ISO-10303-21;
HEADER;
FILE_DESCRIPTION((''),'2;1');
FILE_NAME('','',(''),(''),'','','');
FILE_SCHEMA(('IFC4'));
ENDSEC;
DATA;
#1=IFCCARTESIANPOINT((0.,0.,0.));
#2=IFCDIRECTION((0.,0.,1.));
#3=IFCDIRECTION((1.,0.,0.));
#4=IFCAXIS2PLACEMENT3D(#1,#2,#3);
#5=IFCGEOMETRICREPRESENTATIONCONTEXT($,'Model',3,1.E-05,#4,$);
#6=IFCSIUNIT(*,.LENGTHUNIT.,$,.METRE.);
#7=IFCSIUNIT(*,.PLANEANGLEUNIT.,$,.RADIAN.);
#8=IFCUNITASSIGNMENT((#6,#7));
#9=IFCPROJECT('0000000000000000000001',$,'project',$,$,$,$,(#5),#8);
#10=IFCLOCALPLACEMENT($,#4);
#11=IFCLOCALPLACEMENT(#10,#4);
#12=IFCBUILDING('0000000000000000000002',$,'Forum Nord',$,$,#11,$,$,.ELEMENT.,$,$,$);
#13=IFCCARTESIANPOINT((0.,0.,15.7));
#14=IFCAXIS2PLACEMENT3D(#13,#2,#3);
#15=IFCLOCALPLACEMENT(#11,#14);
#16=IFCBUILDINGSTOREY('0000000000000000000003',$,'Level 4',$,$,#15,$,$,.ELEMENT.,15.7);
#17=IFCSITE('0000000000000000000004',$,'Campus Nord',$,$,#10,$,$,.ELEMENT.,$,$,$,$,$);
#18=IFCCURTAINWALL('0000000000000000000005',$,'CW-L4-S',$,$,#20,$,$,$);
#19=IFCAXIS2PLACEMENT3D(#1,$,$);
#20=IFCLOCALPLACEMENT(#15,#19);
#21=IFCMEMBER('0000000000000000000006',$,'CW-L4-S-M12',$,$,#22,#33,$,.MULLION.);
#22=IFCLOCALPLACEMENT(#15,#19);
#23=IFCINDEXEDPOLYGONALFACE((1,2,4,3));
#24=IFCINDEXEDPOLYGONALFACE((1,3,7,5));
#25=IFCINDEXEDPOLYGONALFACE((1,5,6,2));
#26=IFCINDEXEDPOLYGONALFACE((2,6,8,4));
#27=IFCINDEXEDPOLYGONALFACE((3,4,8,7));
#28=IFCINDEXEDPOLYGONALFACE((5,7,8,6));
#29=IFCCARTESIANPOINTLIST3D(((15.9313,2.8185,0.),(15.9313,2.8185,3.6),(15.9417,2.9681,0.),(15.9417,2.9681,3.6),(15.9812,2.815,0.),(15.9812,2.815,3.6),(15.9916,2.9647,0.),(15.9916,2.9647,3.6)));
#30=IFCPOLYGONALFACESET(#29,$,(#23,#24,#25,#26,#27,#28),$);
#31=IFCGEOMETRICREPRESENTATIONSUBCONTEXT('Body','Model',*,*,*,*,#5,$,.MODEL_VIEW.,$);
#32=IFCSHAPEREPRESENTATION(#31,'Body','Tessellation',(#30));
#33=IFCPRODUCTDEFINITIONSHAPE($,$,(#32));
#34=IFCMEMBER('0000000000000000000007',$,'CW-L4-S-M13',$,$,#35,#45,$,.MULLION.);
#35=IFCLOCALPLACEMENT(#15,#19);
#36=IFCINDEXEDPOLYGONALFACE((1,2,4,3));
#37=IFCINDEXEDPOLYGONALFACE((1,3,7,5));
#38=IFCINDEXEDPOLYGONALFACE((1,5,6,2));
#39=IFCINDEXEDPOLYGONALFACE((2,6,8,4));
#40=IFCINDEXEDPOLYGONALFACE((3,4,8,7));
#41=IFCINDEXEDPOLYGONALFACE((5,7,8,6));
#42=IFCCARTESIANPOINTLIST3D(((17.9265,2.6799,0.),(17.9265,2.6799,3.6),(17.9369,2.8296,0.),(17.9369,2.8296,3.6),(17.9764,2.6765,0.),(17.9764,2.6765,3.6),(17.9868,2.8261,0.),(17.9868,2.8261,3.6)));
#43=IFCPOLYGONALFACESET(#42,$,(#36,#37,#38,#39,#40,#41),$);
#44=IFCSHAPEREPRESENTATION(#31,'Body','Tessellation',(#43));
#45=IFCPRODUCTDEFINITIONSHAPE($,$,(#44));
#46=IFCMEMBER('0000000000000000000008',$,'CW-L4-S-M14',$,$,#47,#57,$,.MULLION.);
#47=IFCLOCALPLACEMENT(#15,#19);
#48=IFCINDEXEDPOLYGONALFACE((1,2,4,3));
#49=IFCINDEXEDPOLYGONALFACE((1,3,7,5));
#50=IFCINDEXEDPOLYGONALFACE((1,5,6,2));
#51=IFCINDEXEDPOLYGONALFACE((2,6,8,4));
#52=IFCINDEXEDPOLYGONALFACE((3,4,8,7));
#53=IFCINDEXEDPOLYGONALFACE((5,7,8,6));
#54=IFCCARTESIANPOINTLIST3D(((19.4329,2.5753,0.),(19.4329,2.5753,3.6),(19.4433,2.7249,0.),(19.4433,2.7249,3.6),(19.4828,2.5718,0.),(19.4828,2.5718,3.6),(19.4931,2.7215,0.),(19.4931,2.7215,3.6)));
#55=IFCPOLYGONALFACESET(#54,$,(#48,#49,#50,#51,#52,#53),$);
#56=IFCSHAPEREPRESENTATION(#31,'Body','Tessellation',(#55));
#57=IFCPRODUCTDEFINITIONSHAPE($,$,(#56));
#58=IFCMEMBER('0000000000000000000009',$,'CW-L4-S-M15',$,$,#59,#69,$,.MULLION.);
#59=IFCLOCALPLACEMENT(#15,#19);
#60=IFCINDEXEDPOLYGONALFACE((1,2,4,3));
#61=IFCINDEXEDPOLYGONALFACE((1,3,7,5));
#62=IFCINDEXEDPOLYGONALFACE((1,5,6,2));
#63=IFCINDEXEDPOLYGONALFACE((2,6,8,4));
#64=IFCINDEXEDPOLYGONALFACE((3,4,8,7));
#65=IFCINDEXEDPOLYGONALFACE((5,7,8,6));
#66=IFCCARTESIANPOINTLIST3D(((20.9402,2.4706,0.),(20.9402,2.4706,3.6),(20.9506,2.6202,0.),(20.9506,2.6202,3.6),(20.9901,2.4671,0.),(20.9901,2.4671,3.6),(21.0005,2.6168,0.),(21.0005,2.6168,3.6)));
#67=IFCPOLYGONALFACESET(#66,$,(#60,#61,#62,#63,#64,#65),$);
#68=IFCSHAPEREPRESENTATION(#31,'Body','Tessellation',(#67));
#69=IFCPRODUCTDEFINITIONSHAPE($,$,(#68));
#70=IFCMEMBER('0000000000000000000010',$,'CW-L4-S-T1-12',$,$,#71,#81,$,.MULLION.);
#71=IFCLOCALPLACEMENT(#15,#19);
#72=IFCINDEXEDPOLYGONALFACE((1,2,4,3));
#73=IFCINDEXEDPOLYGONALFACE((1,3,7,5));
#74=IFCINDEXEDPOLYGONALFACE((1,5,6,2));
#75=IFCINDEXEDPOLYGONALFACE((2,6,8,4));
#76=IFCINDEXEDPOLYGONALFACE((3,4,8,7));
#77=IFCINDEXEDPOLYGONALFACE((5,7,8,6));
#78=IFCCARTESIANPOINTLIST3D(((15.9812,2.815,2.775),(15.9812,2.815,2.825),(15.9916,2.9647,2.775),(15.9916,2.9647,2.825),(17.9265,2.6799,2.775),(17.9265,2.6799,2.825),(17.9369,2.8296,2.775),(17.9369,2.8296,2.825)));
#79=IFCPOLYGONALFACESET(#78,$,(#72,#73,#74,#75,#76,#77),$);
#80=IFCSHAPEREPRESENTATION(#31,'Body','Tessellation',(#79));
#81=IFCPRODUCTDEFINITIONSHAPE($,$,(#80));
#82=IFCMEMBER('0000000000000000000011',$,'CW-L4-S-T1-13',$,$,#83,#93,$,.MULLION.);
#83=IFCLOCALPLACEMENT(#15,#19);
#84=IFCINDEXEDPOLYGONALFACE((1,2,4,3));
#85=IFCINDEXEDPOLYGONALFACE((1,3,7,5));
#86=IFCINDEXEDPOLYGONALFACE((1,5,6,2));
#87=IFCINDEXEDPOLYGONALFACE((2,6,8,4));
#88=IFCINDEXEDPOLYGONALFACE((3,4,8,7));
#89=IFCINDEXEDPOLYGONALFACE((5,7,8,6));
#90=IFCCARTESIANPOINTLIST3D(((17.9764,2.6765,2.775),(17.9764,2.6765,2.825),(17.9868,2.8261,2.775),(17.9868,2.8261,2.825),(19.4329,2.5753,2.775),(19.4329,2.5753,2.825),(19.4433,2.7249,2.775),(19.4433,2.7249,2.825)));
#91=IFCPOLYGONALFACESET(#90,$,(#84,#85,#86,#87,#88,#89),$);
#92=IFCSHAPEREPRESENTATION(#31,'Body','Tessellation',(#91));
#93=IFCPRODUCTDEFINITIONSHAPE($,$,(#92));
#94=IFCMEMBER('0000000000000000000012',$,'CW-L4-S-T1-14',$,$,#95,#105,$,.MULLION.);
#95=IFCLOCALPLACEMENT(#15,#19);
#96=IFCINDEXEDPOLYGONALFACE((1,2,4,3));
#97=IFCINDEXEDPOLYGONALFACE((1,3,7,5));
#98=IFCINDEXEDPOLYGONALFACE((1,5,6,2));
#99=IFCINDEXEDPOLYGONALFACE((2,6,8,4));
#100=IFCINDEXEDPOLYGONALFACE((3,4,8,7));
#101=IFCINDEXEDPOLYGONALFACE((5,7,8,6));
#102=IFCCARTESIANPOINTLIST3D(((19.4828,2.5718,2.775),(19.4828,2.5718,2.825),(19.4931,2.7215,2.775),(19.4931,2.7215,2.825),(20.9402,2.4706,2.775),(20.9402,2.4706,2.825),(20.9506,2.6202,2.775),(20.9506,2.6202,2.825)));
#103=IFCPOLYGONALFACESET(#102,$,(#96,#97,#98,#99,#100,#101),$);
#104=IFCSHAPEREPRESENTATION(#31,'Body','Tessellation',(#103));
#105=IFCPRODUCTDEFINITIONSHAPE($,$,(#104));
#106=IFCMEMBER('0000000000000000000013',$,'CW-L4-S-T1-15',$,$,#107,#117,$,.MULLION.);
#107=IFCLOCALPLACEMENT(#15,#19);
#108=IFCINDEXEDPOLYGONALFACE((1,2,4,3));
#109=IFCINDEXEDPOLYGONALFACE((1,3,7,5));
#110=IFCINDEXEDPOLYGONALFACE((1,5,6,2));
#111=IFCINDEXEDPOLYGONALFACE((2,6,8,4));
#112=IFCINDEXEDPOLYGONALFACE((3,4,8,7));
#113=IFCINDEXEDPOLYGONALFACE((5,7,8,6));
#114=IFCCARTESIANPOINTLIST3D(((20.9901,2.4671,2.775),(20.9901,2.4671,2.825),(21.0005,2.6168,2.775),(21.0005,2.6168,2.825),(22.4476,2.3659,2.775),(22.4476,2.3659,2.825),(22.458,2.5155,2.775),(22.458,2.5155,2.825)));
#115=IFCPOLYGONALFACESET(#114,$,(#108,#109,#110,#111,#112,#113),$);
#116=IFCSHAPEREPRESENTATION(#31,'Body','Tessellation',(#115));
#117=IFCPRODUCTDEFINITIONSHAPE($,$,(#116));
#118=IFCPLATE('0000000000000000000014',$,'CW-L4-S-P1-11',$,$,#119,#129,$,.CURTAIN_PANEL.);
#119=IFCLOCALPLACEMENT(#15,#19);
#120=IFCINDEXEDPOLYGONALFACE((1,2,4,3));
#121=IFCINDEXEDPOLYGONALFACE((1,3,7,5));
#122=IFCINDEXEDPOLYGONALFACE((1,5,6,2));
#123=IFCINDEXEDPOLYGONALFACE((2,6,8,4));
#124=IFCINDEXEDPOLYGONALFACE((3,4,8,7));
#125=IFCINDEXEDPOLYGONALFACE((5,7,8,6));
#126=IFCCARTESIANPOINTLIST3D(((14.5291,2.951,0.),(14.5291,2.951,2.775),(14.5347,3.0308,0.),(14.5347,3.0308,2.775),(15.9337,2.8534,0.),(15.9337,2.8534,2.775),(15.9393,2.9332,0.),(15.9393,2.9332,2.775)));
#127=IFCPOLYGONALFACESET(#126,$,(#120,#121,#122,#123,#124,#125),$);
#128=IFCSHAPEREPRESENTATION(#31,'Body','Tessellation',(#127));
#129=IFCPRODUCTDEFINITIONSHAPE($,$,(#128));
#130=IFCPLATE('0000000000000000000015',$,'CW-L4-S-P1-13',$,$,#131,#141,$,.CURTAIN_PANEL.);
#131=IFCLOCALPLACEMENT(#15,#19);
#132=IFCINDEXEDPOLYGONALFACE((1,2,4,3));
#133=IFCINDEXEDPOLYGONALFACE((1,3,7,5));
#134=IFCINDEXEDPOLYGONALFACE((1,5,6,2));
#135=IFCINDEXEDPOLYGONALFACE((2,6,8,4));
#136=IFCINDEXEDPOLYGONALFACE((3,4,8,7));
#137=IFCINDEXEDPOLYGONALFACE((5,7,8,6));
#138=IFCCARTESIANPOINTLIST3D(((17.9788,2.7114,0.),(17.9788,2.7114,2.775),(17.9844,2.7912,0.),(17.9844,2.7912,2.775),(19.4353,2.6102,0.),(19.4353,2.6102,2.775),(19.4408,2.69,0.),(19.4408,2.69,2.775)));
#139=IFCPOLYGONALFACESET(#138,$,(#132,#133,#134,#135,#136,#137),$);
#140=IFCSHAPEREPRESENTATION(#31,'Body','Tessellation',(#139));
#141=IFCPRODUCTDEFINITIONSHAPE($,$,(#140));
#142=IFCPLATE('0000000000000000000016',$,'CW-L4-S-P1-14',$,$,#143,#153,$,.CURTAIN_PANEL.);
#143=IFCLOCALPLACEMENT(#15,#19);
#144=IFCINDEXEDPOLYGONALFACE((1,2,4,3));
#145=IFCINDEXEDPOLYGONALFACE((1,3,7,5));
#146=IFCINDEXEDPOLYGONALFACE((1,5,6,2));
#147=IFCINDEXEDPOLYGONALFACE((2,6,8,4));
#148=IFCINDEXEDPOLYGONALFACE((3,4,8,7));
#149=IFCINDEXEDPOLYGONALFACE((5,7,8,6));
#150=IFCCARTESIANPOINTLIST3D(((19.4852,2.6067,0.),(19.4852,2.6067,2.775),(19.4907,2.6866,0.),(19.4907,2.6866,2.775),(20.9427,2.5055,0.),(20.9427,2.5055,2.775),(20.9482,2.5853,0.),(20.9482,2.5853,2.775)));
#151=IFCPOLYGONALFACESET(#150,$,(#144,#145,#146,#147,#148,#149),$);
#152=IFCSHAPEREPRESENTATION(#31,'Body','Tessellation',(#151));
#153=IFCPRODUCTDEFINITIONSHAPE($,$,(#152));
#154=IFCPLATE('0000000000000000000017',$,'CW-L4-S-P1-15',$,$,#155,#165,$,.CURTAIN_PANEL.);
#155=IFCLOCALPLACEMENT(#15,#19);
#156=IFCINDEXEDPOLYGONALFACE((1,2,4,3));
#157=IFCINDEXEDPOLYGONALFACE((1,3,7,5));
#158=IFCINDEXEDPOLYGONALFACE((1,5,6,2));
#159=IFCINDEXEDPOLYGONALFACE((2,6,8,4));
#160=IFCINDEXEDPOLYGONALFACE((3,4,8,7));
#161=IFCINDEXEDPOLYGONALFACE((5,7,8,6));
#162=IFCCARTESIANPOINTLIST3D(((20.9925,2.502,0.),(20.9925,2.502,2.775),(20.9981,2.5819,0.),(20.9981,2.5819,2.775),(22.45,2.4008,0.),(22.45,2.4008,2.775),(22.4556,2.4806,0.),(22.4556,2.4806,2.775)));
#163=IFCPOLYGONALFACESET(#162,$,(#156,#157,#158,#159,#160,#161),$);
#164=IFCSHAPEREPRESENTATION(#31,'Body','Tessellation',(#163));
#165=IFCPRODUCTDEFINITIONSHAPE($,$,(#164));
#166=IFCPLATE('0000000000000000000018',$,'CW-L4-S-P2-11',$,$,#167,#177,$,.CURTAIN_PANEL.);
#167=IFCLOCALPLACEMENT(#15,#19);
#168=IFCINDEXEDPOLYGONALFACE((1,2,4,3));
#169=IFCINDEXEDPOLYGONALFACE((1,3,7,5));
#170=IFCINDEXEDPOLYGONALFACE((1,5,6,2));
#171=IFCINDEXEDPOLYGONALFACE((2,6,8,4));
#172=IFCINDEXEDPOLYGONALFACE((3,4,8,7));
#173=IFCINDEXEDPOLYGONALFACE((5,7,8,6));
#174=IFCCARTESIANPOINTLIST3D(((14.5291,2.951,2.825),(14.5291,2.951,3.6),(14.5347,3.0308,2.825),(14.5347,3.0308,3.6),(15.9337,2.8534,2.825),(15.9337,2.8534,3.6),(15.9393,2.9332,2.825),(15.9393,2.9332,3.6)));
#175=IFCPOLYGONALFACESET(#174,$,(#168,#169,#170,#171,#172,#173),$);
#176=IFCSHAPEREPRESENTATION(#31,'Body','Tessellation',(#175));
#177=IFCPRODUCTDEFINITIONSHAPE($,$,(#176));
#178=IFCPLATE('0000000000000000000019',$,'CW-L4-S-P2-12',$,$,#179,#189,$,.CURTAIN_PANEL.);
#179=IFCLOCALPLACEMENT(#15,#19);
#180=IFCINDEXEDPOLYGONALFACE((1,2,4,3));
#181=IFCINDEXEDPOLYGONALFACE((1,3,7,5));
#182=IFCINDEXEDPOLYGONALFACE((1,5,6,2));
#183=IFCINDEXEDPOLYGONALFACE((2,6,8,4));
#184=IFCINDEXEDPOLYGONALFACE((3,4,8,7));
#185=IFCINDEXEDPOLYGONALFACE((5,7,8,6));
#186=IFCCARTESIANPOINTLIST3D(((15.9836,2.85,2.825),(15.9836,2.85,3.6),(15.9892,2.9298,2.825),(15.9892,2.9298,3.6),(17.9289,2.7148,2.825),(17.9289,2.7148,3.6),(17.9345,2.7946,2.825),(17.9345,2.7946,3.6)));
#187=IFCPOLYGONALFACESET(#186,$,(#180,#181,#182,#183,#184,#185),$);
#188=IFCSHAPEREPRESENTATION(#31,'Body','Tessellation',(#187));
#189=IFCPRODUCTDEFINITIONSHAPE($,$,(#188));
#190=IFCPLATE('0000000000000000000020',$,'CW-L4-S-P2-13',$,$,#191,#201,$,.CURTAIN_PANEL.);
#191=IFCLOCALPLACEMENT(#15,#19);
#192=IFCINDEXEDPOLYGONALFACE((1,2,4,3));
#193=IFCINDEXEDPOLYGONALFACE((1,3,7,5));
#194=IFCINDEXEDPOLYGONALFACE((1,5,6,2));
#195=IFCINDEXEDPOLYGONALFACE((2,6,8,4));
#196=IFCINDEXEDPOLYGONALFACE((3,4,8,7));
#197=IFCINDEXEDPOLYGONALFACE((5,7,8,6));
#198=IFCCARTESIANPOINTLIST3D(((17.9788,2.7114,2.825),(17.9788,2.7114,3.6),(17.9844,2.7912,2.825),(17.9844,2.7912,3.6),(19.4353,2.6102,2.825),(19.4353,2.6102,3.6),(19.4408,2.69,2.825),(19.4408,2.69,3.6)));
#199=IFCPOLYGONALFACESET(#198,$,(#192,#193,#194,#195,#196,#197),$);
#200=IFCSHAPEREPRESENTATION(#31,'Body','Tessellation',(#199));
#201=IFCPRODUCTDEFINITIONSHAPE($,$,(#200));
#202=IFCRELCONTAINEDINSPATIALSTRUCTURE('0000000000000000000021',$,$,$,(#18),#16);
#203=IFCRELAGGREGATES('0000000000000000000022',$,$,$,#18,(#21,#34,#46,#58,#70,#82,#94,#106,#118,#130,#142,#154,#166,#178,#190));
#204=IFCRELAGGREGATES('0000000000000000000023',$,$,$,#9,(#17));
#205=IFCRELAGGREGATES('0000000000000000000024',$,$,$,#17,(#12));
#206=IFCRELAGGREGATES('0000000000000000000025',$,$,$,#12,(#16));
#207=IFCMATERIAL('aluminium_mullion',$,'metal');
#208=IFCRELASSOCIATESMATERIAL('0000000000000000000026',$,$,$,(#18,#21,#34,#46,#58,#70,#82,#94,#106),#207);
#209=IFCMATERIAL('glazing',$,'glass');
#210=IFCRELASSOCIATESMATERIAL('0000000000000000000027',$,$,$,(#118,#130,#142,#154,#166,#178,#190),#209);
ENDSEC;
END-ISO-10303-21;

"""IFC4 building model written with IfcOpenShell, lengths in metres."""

from ifc_helpers import new_model, si_unit, frame, frame_2d, origin_with_axes, origin_2d_with_axis, place, context, subcontext, project, spatial, rectangle, extrude, material, element, aggregate, save


model = new_model("IFC4")

# Units and contexts
model_context = context("Model", 3, precision=1e-05, world=origin_with_axes())
body_context = subcontext(model_context, "Body", "Model", "MODEL_VIEW")
ifc_project = project(units=[si_unit("LENGTHUNIT", "METRE"), si_unit("PLANEANGLEUNIT", "RADIAN")], contexts=[model_context])

# Site, building, storey
site_placement = place(None, origin_with_axes())
site = spatial("IfcSite", under=ifc_project, at=site_placement, Name="Campus Nord", CompositionType="ELEMENT")
building_placement = place(site_placement, origin_with_axes())
building = spatial("IfcBuilding", under=site, at=building_placement, Name="Forum Nord", CompositionType="ELEMENT")
storey_placement = place(building_placement, frame((0.0, 0.0, 15.7), z_axis=(0.0, 0.0, 1.0), x_axis=(1.0, 0.0, 0.0)))
storey = spatial("IfcBuildingStorey", under=building, at=storey_placement, Name="Level 4", CompositionType="ELEMENT", Elevation=15.7)

# Curtain wall, members, plates
ifc_material_1 = material(Name="aluminium_mullion", Category="metal")
curtain_wall_placement = place(storey_placement, origin_with_axes())
curtain_wall = element("IfcCurtainWall", 1, at=curtain_wall_placement, inside=storey, material=ifc_material_1, Name="CW-L4-S")
member_1_placement = place(storey_placement, frame((15.9614, 2.8916, 0.0), z_axis=(0.0, 0.0, 1.0), x_axis=(0.9976, -0.06929, 0.0)))
member_1 = element("IfcMember", 2, at=member_1_placement, material=ifc_material_1, Name="CW-L4-S-M12", PredefinedType="MULLION", context=body_context, shape_type="SweptSolid", body=[
    extrude(rectangle(XDim=0.05, YDim=0.15, at=origin_2d_with_axis()), origin_with_axes(), (0.0, 0.0, 1.0), 3.6),
])
member_2_placement = place(storey_placement, frame((17.9566, 2.753, 0.0), z_axis=(0.0, 0.0, 1.0), x_axis=(0.9976, -0.06929, 0.0)))
member_2 = element("IfcMember", 3, at=member_2_placement, material=ifc_material_1, Name="CW-L4-S-M13", PredefinedType="MULLION", context=body_context, shape_type="SweptSolid", body=[
    extrude(rectangle(XDim=0.05, YDim=0.15, at=origin_2d_with_axis()), origin_with_axes(), (0.0, 0.0, 1.0), 3.6),
])
member_3_placement = place(storey_placement, frame((19.463, 2.6484, 0.0), z_axis=(0.0, 0.0, 1.0), x_axis=(0.9976, -0.06929, 0.0)))
member_3 = element("IfcMember", 4, at=member_3_placement, material=ifc_material_1, Name="CW-L4-S-M14", PredefinedType="MULLION", context=body_context, shape_type="SweptSolid", body=[
    extrude(rectangle(XDim=0.05, YDim=0.15, at=origin_2d_with_axis()), origin_with_axes(), (0.0, 0.0, 1.0), 3.6),
])
member_4_placement = place(storey_placement, frame((20.9704, 2.5437, 0.0), z_axis=(0.0, 0.0, 1.0), x_axis=(0.9976, -0.06929, 0.0)))
member_4 = element("IfcMember", 5, at=member_4_placement, material=ifc_material_1, Name="CW-L4-S-M15", PredefinedType="MULLION", context=body_context, shape_type="SweptSolid", body=[
    extrude(rectangle(XDim=0.05, YDim=0.15, at=origin_2d_with_axis()), origin_with_axes(), (0.0, 0.0, 1.0), 3.6),
])
member_5_placement = place(storey_placement, frame((15.9864, 2.8899, 2.8), z_axis=(0.9976, -0.06929, 0.0), x_axis=(0.06929, 0.9976, 0.0)))
member_5 = element("IfcMember", 6, at=member_5_placement, material=ifc_material_1, Name="CW-L4-S-T1-12", PredefinedType="MULLION", context=body_context, shape_type="SweptSolid", body=[
    extrude(rectangle(XDim=0.15, YDim=0.05, at=origin_2d_with_axis()), origin_with_axes(), (0.0, 0.0, 1.0), 1.95),
])
member_6_placement = place(storey_placement, frame((17.9816, 2.7513, 2.8), z_axis=(0.9976, -0.06929, 0.0), x_axis=(0.06929, 0.9976, 0.0)))
member_6 = element("IfcMember", 7, at=member_6_placement, material=ifc_material_1, Name="CW-L4-S-T1-13", PredefinedType="MULLION", context=body_context, shape_type="SweptSolid", body=[
    extrude(rectangle(XDim=0.15, YDim=0.05, at=origin_2d_with_axis()), origin_with_axes(), (0.0, 0.0, 1.0), 1.46),
])
member_7_placement = place(storey_placement, frame((19.488, 2.6467, 2.8), z_axis=(0.9976, -0.06929, 0.0), x_axis=(0.06929, 0.9976, 0.0)))
member_7 = element("IfcMember", 8, at=member_7_placement, material=ifc_material_1, Name="CW-L4-S-T1-14", PredefinedType="MULLION", context=body_context, shape_type="SweptSolid", body=[
    extrude(rectangle(XDim=0.15, YDim=0.05, at=origin_2d_with_axis()), origin_with_axes(), (0.0, 0.0, 1.0), 1.461),
])
member_8_placement = place(storey_placement, frame((20.9953, 2.5419, 2.8), z_axis=(0.9976, -0.06929, 0.0), x_axis=(0.06929, 0.9976, 0.0)))
member_8 = element("IfcMember", 9, at=member_8_placement, material=ifc_material_1, Name="CW-L4-S-T1-15", PredefinedType="MULLION", context=body_context, shape_type="SweptSolid", body=[
    extrude(rectangle(XDim=0.15, YDim=0.05, at=origin_2d_with_axis()), origin_with_axes(), (0.0, 0.0, 1.0), 1.461),
])
ifc_material_2 = material(Name="glazing", Category="glass")
plate_1_placement = place(storey_placement, frame((14.5319, 2.9909, 0.0), z_axis=(0.0, 0.0, 1.0), x_axis=(0.9976, -0.06929, 0.0)))
plate_1 = element("IfcPlate", 10, at=plate_1_placement, material=ifc_material_2, Name="CW-L4-S-P1-11", PredefinedType="CURTAIN_PANEL", context=body_context, shape_type="SweptSolid", body=[
    extrude(rectangle(XDim=1.408, YDim=0.08, at=frame_2d((0.704, 0.0), x_axis=(1.0, 0.0))), origin_with_axes(), (0.0, 0.0, 1.0), 2.775),
])
plate_2_placement = place(storey_placement, frame((17.9816, 2.7513, 0.0), z_axis=(0.0, 0.0, 1.0), x_axis=(0.9976, -0.06929, 0.0)))
plate_2 = element("IfcPlate", 11, at=plate_2_placement, material=ifc_material_2, Name="CW-L4-S-P1-13", PredefinedType="CURTAIN_PANEL", context=body_context, shape_type="SweptSolid", body=[
    extrude(rectangle(XDim=1.46, YDim=0.08, at=frame_2d((0.73, 0.0), x_axis=(1.0, 0.0))), origin_with_axes(), (0.0, 0.0, 1.0), 2.775),
])
plate_3_placement = place(storey_placement, frame((19.488, 2.6467, 0.0), z_axis=(0.0, 0.0, 1.0), x_axis=(0.9976, -0.06929, 0.0)))
plate_3 = element("IfcPlate", 12, at=plate_3_placement, material=ifc_material_2, Name="CW-L4-S-P1-14", PredefinedType="CURTAIN_PANEL", context=body_context, shape_type="SweptSolid", body=[
    extrude(rectangle(XDim=1.461, YDim=0.08, at=frame_2d((0.7305, 0.0), x_axis=(1.0, 0.0))), origin_with_axes(), (0.0, 0.0, 1.0), 2.775),
])
plate_4_placement = place(storey_placement, frame((20.9953, 2.5419, 0.0), z_axis=(0.0, 0.0, 1.0), x_axis=(0.9976, -0.06929, 0.0)))
plate_4 = element("IfcPlate", 13, at=plate_4_placement, material=ifc_material_2, Name="CW-L4-S-P1-15", PredefinedType="CURTAIN_PANEL", context=body_context, shape_type="SweptSolid", body=[
    extrude(rectangle(XDim=1.461, YDim=0.08, at=frame_2d((0.7305, 0.0), x_axis=(1.0, 0.0))), origin_with_axes(), (0.0, 0.0, 1.0), 2.775),
])
plate_5_placement = place(storey_placement, frame((14.5319, 2.9909, 2.825), z_axis=(0.0, 0.0, 1.0), x_axis=(0.9976, -0.06929, 0.0)))
plate_5 = element("IfcPlate", 14, at=plate_5_placement, material=ifc_material_2, Name="CW-L4-S-P2-11", PredefinedType="CURTAIN_PANEL", context=body_context, shape_type="SweptSolid", body=[
    extrude(rectangle(XDim=1.408, YDim=0.08, at=frame_2d((0.704, 0.0), x_axis=(1.0, 0.0))), origin_with_axes(), (0.0, 0.0, 1.0), 0.775),
])
plate_6_placement = place(storey_placement, frame((15.9864, 2.8899, 2.825), z_axis=(0.0, 0.0, 1.0), x_axis=(0.9976, -0.06929, 0.0)))
plate_6 = element("IfcPlate", 15, at=plate_6_placement, material=ifc_material_2, Name="CW-L4-S-P2-12", PredefinedType="CURTAIN_PANEL", context=body_context, shape_type="SweptSolid", body=[
    extrude(rectangle(XDim=1.95, YDim=0.08, at=frame_2d((0.975, 0.0), x_axis=(1.0, 0.0))), origin_with_axes(), (0.0, 0.0, 1.0), 0.775),
])
plate_7_placement = place(storey_placement, frame((17.9816, 2.7513, 2.825), z_axis=(0.0, 0.0, 1.0), x_axis=(0.9976, -0.06929, 0.0)))
plate_7 = element("IfcPlate", 16, at=plate_7_placement, material=ifc_material_2, Name="CW-L4-S-P2-13", PredefinedType="CURTAIN_PANEL", context=body_context, shape_type="SweptSolid", body=[
    extrude(rectangle(XDim=1.46, YDim=0.08, at=frame_2d((0.73, 0.0), x_axis=(1.0, 0.0))), origin_with_axes(), (0.0, 0.0, 1.0), 0.775),
])
aggregate(curtain_wall, [member_1, member_2, member_3, member_4, member_5, member_6, member_7, member_8, plate_1, plate_2, plate_3, plate_4, plate_5, plate_6, plate_7])

save(model, "model.ifc")
